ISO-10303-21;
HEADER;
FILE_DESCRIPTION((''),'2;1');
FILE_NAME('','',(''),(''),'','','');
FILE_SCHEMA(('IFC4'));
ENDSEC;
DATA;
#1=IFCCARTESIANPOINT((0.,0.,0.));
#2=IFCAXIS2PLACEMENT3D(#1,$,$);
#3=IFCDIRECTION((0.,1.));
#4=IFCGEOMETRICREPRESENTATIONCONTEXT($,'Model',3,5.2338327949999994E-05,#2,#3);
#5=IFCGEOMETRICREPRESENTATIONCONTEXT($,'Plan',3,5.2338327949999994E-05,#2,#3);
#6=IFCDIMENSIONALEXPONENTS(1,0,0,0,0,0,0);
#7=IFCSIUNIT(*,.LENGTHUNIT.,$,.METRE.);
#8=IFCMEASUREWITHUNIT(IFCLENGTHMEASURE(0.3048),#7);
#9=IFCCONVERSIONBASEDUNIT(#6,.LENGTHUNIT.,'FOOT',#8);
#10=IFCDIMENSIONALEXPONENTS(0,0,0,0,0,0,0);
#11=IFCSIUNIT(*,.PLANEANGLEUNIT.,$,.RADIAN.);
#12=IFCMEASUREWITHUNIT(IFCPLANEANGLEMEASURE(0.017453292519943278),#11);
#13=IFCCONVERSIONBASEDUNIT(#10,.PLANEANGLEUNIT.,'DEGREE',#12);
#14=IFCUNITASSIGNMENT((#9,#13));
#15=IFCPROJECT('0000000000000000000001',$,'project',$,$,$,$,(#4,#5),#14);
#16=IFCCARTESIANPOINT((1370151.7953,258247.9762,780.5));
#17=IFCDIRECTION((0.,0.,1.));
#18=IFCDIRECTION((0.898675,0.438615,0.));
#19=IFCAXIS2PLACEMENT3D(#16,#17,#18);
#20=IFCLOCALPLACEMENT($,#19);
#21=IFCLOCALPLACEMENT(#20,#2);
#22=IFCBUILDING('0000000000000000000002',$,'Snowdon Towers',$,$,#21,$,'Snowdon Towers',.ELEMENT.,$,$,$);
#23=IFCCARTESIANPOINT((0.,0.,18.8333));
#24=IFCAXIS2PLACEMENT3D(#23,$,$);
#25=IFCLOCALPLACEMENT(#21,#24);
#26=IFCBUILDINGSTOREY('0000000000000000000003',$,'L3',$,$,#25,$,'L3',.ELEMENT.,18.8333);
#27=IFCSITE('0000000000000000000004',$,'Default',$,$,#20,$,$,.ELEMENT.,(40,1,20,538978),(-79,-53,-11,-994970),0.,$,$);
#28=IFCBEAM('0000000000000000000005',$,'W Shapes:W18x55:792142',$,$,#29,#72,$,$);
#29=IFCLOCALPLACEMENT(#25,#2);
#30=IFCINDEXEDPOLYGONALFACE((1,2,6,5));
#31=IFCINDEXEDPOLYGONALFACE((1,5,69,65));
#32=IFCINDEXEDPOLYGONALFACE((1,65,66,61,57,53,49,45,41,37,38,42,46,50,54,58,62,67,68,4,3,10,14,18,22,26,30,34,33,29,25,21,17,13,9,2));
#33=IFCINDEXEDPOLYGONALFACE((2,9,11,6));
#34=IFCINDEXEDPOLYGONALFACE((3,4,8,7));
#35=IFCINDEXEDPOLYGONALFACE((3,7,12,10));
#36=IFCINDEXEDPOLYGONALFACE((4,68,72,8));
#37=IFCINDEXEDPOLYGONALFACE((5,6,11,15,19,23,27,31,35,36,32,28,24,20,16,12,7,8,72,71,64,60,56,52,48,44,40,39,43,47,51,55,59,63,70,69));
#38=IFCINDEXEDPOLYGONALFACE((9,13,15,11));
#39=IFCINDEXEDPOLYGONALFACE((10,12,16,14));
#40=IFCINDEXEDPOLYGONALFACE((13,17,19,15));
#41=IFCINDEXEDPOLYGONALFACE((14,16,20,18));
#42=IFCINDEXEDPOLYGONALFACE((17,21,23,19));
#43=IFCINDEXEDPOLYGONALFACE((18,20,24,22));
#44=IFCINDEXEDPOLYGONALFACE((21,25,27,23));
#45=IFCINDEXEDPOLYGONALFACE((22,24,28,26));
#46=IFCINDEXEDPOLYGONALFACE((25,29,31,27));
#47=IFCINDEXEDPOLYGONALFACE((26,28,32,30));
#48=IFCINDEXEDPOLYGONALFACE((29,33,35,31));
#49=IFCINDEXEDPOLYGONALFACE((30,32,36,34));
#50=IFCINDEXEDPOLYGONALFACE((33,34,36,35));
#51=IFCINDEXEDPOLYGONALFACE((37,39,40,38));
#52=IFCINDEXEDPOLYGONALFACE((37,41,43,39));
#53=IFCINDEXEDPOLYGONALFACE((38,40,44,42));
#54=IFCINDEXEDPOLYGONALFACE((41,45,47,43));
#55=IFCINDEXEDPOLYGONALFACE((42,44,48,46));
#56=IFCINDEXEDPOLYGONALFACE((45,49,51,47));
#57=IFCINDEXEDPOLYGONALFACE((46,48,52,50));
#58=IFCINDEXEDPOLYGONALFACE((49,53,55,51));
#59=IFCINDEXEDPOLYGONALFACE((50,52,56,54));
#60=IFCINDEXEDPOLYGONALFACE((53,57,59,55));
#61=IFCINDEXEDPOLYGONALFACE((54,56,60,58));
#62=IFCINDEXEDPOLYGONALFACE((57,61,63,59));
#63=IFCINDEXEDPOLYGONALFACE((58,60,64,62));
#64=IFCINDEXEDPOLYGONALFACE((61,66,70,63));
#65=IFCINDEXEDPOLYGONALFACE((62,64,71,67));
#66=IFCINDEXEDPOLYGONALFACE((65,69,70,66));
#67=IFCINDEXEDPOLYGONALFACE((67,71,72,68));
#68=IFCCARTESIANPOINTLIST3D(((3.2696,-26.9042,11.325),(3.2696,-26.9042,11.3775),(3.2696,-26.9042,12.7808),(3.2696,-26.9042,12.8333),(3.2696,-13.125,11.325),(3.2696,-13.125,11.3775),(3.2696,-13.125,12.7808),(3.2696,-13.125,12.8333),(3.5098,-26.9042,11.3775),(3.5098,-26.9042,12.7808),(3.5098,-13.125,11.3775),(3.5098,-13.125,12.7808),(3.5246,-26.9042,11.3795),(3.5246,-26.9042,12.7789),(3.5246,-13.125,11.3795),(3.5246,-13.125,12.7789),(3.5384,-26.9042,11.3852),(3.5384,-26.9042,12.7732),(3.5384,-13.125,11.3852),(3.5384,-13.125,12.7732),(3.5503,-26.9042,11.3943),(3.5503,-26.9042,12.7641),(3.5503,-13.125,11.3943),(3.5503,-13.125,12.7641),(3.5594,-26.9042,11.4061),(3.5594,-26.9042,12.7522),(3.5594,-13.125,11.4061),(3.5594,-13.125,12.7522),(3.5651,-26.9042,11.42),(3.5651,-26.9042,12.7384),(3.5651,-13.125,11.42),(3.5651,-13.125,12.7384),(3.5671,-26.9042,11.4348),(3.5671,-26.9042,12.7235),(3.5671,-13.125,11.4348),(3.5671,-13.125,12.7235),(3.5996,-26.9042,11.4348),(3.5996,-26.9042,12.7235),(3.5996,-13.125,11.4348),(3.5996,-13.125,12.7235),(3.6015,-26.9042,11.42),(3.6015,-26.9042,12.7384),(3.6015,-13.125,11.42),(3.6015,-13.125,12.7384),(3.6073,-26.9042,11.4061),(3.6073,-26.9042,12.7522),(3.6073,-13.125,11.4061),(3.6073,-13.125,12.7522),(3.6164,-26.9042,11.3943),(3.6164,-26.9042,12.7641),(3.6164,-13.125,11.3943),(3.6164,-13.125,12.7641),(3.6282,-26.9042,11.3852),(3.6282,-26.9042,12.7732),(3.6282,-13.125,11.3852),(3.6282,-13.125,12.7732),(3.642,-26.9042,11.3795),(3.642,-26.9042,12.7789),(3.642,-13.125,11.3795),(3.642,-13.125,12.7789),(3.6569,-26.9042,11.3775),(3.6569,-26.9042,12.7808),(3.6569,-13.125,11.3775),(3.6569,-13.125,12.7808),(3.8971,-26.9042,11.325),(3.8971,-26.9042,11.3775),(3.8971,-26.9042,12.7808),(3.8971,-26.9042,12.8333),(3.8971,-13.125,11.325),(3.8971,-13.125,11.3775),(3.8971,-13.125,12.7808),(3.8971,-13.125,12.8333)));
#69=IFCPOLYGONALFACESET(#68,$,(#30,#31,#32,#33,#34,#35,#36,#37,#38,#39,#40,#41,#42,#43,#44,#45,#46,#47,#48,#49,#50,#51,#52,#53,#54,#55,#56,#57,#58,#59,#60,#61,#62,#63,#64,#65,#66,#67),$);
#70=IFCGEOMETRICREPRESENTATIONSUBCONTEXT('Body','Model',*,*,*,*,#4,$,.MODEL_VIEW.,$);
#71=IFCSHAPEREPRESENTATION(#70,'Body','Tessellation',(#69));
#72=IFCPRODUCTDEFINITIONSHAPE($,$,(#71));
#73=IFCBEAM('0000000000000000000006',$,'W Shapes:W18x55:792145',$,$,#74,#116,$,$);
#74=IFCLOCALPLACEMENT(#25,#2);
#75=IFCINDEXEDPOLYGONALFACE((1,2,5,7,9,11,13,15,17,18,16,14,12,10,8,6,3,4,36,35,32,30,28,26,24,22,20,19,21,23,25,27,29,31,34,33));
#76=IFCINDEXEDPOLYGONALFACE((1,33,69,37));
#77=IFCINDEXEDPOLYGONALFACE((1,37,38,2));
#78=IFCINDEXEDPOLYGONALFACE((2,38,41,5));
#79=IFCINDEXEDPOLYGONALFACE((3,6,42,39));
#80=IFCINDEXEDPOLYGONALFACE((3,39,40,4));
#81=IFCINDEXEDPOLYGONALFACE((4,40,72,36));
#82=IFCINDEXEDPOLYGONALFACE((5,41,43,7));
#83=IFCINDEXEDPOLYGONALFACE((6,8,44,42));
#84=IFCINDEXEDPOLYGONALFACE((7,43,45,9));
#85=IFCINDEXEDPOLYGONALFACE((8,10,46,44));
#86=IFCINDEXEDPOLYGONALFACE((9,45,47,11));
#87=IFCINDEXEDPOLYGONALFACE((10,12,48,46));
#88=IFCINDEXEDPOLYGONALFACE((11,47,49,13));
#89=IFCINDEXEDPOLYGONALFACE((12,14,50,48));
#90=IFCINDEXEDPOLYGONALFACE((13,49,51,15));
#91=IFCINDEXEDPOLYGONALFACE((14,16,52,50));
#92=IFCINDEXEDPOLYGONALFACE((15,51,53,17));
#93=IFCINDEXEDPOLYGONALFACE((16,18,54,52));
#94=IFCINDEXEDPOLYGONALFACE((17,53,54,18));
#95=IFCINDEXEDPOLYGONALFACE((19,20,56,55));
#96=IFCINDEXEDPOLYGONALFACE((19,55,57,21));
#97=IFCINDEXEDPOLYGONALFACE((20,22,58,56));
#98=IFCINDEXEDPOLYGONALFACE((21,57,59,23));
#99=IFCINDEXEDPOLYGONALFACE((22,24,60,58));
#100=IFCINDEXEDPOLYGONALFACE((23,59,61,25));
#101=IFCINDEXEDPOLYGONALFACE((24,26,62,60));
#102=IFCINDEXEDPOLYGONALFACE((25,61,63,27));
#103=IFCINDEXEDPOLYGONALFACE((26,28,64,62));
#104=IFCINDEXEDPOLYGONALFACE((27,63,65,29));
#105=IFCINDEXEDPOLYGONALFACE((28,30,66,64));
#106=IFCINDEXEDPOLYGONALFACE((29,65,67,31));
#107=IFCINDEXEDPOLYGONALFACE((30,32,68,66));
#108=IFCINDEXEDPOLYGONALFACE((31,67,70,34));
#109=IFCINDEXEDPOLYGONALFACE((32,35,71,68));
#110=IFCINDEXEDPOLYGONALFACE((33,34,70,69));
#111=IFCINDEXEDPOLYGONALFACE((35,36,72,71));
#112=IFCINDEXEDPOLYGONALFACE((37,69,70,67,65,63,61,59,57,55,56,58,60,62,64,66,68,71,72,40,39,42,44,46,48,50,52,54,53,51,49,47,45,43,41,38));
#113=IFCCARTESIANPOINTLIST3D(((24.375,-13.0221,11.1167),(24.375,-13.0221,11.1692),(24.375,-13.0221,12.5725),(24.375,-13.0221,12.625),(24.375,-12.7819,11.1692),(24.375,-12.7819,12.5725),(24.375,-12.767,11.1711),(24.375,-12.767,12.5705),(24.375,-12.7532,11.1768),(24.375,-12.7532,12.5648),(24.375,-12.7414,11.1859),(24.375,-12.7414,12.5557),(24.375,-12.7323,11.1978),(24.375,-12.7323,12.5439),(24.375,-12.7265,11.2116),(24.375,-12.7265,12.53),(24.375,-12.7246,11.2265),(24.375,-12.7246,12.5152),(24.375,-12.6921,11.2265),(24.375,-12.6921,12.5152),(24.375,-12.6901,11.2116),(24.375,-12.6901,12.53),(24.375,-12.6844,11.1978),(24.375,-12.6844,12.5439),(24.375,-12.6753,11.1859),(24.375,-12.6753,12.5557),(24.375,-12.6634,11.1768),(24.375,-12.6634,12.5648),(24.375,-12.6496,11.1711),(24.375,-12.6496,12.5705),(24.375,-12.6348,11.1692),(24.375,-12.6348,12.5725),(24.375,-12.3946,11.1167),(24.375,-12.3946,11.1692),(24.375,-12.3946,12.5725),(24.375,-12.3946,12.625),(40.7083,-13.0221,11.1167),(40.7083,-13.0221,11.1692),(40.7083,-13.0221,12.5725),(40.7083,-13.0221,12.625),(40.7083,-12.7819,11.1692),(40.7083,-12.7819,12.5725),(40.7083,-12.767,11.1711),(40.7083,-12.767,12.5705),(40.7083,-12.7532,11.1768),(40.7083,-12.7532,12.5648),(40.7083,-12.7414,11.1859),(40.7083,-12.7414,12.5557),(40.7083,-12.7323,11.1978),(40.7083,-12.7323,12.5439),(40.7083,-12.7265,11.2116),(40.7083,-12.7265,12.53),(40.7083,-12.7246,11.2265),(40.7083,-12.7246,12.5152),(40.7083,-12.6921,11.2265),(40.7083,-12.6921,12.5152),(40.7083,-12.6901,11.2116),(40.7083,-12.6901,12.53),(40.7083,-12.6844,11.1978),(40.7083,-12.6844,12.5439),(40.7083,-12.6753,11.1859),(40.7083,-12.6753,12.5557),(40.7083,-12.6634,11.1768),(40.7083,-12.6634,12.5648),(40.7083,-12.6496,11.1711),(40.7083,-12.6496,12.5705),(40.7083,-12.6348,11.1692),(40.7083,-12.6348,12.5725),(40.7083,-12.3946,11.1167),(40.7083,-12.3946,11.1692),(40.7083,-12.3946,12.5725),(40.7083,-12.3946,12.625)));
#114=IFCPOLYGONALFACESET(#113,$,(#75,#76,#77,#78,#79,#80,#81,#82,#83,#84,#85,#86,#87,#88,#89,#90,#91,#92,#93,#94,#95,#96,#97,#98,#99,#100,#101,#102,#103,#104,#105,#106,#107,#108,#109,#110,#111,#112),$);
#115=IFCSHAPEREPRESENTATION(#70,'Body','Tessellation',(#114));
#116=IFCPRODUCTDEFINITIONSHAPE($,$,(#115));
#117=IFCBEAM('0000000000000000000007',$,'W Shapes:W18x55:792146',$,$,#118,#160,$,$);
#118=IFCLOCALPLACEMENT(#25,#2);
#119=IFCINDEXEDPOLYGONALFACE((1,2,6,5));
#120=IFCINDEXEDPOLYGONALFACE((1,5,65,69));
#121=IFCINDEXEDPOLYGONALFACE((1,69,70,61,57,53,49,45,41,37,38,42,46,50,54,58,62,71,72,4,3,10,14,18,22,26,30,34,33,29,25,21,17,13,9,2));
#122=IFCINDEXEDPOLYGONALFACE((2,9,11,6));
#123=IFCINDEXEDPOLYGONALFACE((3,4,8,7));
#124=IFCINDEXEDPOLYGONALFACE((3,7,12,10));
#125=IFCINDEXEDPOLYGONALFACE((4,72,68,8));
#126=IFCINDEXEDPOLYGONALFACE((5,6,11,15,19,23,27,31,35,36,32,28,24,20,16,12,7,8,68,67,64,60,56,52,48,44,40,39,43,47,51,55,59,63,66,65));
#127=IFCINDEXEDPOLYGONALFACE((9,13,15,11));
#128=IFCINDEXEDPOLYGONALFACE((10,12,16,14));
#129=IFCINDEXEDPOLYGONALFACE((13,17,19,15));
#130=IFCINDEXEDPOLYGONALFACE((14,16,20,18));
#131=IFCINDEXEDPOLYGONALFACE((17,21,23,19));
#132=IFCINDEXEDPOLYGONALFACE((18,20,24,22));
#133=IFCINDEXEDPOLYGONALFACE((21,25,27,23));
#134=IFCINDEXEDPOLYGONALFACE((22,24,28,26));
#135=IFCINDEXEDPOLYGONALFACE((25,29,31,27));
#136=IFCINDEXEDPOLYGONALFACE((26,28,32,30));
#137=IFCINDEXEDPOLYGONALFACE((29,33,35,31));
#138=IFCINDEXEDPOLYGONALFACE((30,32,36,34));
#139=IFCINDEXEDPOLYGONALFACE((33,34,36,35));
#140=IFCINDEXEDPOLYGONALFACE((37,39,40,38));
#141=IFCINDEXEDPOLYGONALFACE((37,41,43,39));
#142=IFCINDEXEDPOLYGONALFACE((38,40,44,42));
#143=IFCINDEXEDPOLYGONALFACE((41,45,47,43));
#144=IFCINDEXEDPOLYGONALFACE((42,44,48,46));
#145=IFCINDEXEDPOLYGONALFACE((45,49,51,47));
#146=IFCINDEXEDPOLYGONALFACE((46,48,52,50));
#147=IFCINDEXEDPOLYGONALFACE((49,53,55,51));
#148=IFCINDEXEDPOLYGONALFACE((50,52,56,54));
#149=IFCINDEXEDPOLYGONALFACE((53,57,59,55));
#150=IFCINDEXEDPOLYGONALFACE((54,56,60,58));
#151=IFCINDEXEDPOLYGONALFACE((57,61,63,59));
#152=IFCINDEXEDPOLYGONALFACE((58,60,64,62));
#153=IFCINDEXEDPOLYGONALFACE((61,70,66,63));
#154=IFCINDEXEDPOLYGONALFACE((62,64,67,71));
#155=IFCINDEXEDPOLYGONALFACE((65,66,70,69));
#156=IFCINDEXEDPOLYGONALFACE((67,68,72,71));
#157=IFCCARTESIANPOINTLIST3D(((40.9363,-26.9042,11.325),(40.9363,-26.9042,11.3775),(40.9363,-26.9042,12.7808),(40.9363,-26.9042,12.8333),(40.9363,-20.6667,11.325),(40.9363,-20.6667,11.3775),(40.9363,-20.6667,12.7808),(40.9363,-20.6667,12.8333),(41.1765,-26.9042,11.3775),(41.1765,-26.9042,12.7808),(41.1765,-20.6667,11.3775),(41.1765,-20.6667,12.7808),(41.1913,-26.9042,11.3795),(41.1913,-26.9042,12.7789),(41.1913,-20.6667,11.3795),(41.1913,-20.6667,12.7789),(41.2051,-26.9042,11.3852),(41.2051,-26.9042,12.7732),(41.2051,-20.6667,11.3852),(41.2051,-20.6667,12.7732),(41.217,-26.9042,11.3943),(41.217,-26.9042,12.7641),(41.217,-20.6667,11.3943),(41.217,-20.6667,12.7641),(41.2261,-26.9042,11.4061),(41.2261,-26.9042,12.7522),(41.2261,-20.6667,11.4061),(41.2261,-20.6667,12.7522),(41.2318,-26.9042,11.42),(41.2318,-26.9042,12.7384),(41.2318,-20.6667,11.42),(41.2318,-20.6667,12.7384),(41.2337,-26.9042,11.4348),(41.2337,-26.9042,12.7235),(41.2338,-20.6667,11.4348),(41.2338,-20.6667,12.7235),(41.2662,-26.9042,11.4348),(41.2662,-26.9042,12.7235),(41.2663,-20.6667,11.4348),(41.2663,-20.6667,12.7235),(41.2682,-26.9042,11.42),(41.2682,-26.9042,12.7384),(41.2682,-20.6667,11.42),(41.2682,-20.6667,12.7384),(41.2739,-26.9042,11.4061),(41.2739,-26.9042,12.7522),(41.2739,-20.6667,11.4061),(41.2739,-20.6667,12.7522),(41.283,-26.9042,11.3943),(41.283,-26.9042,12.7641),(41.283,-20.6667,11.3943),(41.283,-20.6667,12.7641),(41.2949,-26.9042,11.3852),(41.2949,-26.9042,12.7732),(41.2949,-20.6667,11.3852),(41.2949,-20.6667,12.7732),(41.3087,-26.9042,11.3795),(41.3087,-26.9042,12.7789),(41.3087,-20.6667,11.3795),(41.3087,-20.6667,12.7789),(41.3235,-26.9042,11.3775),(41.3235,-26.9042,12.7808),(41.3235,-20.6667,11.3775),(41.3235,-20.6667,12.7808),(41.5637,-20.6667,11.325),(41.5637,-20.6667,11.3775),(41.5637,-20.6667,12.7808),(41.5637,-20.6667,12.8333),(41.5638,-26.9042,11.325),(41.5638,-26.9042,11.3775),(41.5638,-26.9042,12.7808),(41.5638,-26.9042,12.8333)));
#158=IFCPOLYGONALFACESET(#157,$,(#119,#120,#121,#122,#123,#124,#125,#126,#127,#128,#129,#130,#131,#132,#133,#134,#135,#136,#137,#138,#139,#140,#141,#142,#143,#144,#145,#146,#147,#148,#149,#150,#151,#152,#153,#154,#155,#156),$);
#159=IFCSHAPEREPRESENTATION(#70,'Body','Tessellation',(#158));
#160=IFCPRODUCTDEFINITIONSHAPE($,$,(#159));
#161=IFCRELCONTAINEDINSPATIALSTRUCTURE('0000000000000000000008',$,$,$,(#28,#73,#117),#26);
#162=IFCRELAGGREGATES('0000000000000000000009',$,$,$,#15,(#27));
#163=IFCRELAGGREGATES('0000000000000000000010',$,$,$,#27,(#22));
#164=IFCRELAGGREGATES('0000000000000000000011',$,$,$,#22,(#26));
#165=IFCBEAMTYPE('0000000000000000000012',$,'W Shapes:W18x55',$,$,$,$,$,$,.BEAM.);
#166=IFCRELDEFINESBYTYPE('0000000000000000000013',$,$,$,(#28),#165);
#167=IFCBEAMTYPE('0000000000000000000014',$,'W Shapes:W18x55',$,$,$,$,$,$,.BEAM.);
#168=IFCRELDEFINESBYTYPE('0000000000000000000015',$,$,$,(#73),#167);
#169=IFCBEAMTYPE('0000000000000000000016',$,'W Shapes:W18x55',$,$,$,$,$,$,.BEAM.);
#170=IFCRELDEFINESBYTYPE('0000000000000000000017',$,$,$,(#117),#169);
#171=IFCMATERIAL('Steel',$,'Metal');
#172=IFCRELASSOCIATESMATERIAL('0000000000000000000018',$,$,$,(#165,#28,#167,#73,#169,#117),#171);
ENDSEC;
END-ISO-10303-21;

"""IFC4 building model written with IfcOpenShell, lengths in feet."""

from ifc_helpers import new_model, entity, si_unit, converted_unit, direction, frame, origin, place, context, subcontext, project, spatial, line, arc, indexed_curve, outline, extrude, source, transform, mapped, material, type_object, type_shapes, element, save


model = new_model("IFC4")

# Units and contexts
model_context = context("Model", 3, precision=5.2338327949999994e-05, world=origin(), true_north=direction((0.0, 1.0)))
plan_context = context("Plan", 3, precision=5.2338327949999994e-05, world=origin(), true_north=direction((0.0, 1.0)))
body_context = subcontext(model_context, "Body", "Model", "MODEL_VIEW")
ifc_project = project(units=[converted_unit("LENGTHUNIT", "FOOT", entity("IfcLengthMeasure", 0.3048), si_unit("LENGTHUNIT", "METRE"), dimensions=[1, 0, 0, 0, 0, 0, 0]), converted_unit("PLANEANGLEUNIT", "DEGREE", entity("IfcPlaneAngleMeasure", 0.017453292519943278), si_unit("PLANEANGLEUNIT", "RADIAN"), dimensions=[0, 0, 0, 0, 0, 0, 0])], contexts=[model_context, plan_context])

# Site, building, storey
site_placement = place(None, frame((1370151.7953, 258247.9762, 780.5), z_axis=(0.0, 0.0, 1.0), x_axis=(0.898675, 0.438615, 0.0)))
site = spatial("IfcSite", under=ifc_project, at=site_placement, Name="Default", CompositionType="ELEMENT", RefLatitude=(40, 1, 20, 538978), RefLongitude=(-79, -53, -11, -994970), RefElevation=0.0)
building_placement = place(site_placement, origin())
building = spatial("IfcBuilding", under=site, at=building_placement, Name="Snowdon Towers", LongName="Snowdon Towers", CompositionType="ELEMENT")
storey_placement = place(building_placement, frame((0.0, 0.0, 18.8333)))
storey = spatial("IfcBuildingStorey", under=building, at=storey_placement, Name="L3", LongName="L3", CompositionType="ELEMENT", Elevation=18.8333)

# Beams
ifc_material_1 = material(Name="Steel", Category="Metal")
beam_type_1 = type_object("IfcBeamType", Name="W Shapes:W18x55", PredefinedType="BEAM", material=ifc_material_1)
shared_shape_1 = source(origin(), body_context, "Body", "SweptSolid", [
    extrude(outline(indexed_curve([(-0.7542, -0.3138), (-0.7017, -0.3138), (-0.7017, -0.0735), (-0.6849, -0.033), (-0.6444, -0.0162), (0.6444, -0.0162), (0.6849, -0.033), (0.7017, -0.0735), (0.7017, -0.3138), (0.7542, -0.3138), (0.7542, 0.3138), (0.7017, 0.3138), (0.7017, 0.0735), (0.6849, 0.033), (0.6444, 0.0163), (-0.6444, 0.0163), (-0.6849, 0.033), (-0.7017, 0.0735), (-0.7017, 0.3137), (-0.7542, 0.3137)], segments=[line(1, 2, 3), arc(3, 4, 5), line(5, 6), arc(6, 7, 8), line(8, 9, 10, 11, 12, 13), arc(13, 14, 15), line(15, 16), arc(16, 17, 18), line(18, 19, 20, 1)], self_intersect=False)), frame((-7.2292, 0.0, 0.0), z_axis=(1.0, 0.0, 0.0), x_axis=(0.0, 0.0, -1.0)), (0.0, 0.0, 1.0), 13.7792),
])
type_shapes(beam_type_1, [shared_shape_1])
beam_1_placement = place(storey_placement, frame((3.5833, -20.3542, 12.0792), z_axis=(0.0, 0.0, 1.0), x_axis=(0.0, -1.0, 0.0)))
element("IfcBeam", 1, at=beam_1_placement, inside=storey, type_object=beam_type_1, material=ifc_material_1, Name="W Shapes:W18x55:792142", context=body_context, shape_type="MappedRepresentation", body=[
    mapped(shared_shape_1, transform((0.0, 0.0, 0.0), scale=1.0)),
])
beam_type_2 = type_object("IfcBeamType", Name="W Shapes:W18x55", PredefinedType="BEAM", material=ifc_material_1)
shared_shape_2 = source(origin(), body_context, "Body", "SweptSolid", [
    extrude(outline(indexed_curve([(-0.7542, -0.3138), (-0.7017, -0.3138), (-0.7017, -0.0735), (-0.6849, -0.033), (-0.6444, -0.0162), (0.6444, -0.0162), (0.6849, -0.033), (0.7017, -0.0735), (0.7017, -0.3138), (0.7542, -0.3138), (0.7542, 0.3138), (0.7017, 0.3138), (0.7017, 0.0735), (0.6849, 0.033), (0.6444, 0.0163), (-0.6444, 0.0163), (-0.6849, 0.033), (-0.7017, 0.0735), (-0.7017, 0.3137), (-0.7542, 0.3137)], segments=[line(1, 2, 3), arc(3, 4, 5), line(5, 6), arc(6, 7, 8), line(8, 9, 10, 11, 12, 13), arc(13, 14, 15), line(15, 16), arc(16, 17, 18), line(18, 19, 20, 1)], self_intersect=False)), frame((-8.2083, 0.0, 0.0), z_axis=(1.0, 0.0, 0.0), x_axis=(0.0, 0.0, -1.0)), (0.0, 0.0, 1.0), 16.3333),
])
type_shapes(beam_type_2, [shared_shape_2])
beam_2_placement = place(storey_placement, frame((32.5833, -12.7083, 11.8708)))
element("IfcBeam", 2, at=beam_2_placement, inside=storey, type_object=beam_type_2, material=ifc_material_1, Name="W Shapes:W18x55:792145", context=body_context, shape_type="MappedRepresentation", body=[
    mapped(shared_shape_2, transform((0.0, 0.0, 0.0), scale=1.0)),
])
beam_type_3 = type_object("IfcBeamType", Name="W Shapes:W18x55", PredefinedType="BEAM", material=ifc_material_1)
shared_shape_3 = source(origin(), body_context, "Body", "SweptSolid", [
    extrude(outline(indexed_curve([(-0.7542, -0.3138), (-0.7017, -0.3138), (-0.7017, -0.0735), (-0.6849, -0.033), (-0.6444, -0.0162), (0.6444, -0.0162), (0.6849, -0.033), (0.7017, -0.0735), (0.7017, -0.3138), (0.7542, -0.3138), (0.7542, 0.3138), (0.7017, 0.3138), (0.7017, 0.0735), (0.6849, 0.033), (0.6444, 0.0163), (-0.6444, 0.0163), (-0.6849, 0.033), (-0.7017, 0.0735), (-0.7017, 0.3137), (-0.7542, 0.3137)], segments=[line(1, 2, 3), arc(3, 4, 5), line(5, 6), arc(6, 7, 8), line(8, 9, 10, 11, 12, 13), arc(13, 14, 15), line(15, 16), arc(16, 17, 18), line(18, 19, 20, 1)], self_intersect=False)), frame((-3.3958, 0.0, 0.0), z_axis=(1.0, 0.0, 0.0), x_axis=(0.0, 0.0, -1.0)), (0.0, 0.0, 1.0), 6.2375),
])
type_shapes(beam_type_3, [shared_shape_3])
beam_3_placement = place(storey_placement, frame((41.25, -24.0625, 12.0792), z_axis=(0.0, 0.0, 1.0), x_axis=(0.0, -1.0, 0.0)))
element("IfcBeam", 3, at=beam_3_placement, inside=storey, type_object=beam_type_3, material=ifc_material_1, Name="W Shapes:W18x55:792146", context=body_context, shape_type="MappedRepresentation", body=[
    mapped(shared_shape_3, transform((0.0, 0.0, 0.0), scale=1.0)),
])

save(model, "model.ifc")
